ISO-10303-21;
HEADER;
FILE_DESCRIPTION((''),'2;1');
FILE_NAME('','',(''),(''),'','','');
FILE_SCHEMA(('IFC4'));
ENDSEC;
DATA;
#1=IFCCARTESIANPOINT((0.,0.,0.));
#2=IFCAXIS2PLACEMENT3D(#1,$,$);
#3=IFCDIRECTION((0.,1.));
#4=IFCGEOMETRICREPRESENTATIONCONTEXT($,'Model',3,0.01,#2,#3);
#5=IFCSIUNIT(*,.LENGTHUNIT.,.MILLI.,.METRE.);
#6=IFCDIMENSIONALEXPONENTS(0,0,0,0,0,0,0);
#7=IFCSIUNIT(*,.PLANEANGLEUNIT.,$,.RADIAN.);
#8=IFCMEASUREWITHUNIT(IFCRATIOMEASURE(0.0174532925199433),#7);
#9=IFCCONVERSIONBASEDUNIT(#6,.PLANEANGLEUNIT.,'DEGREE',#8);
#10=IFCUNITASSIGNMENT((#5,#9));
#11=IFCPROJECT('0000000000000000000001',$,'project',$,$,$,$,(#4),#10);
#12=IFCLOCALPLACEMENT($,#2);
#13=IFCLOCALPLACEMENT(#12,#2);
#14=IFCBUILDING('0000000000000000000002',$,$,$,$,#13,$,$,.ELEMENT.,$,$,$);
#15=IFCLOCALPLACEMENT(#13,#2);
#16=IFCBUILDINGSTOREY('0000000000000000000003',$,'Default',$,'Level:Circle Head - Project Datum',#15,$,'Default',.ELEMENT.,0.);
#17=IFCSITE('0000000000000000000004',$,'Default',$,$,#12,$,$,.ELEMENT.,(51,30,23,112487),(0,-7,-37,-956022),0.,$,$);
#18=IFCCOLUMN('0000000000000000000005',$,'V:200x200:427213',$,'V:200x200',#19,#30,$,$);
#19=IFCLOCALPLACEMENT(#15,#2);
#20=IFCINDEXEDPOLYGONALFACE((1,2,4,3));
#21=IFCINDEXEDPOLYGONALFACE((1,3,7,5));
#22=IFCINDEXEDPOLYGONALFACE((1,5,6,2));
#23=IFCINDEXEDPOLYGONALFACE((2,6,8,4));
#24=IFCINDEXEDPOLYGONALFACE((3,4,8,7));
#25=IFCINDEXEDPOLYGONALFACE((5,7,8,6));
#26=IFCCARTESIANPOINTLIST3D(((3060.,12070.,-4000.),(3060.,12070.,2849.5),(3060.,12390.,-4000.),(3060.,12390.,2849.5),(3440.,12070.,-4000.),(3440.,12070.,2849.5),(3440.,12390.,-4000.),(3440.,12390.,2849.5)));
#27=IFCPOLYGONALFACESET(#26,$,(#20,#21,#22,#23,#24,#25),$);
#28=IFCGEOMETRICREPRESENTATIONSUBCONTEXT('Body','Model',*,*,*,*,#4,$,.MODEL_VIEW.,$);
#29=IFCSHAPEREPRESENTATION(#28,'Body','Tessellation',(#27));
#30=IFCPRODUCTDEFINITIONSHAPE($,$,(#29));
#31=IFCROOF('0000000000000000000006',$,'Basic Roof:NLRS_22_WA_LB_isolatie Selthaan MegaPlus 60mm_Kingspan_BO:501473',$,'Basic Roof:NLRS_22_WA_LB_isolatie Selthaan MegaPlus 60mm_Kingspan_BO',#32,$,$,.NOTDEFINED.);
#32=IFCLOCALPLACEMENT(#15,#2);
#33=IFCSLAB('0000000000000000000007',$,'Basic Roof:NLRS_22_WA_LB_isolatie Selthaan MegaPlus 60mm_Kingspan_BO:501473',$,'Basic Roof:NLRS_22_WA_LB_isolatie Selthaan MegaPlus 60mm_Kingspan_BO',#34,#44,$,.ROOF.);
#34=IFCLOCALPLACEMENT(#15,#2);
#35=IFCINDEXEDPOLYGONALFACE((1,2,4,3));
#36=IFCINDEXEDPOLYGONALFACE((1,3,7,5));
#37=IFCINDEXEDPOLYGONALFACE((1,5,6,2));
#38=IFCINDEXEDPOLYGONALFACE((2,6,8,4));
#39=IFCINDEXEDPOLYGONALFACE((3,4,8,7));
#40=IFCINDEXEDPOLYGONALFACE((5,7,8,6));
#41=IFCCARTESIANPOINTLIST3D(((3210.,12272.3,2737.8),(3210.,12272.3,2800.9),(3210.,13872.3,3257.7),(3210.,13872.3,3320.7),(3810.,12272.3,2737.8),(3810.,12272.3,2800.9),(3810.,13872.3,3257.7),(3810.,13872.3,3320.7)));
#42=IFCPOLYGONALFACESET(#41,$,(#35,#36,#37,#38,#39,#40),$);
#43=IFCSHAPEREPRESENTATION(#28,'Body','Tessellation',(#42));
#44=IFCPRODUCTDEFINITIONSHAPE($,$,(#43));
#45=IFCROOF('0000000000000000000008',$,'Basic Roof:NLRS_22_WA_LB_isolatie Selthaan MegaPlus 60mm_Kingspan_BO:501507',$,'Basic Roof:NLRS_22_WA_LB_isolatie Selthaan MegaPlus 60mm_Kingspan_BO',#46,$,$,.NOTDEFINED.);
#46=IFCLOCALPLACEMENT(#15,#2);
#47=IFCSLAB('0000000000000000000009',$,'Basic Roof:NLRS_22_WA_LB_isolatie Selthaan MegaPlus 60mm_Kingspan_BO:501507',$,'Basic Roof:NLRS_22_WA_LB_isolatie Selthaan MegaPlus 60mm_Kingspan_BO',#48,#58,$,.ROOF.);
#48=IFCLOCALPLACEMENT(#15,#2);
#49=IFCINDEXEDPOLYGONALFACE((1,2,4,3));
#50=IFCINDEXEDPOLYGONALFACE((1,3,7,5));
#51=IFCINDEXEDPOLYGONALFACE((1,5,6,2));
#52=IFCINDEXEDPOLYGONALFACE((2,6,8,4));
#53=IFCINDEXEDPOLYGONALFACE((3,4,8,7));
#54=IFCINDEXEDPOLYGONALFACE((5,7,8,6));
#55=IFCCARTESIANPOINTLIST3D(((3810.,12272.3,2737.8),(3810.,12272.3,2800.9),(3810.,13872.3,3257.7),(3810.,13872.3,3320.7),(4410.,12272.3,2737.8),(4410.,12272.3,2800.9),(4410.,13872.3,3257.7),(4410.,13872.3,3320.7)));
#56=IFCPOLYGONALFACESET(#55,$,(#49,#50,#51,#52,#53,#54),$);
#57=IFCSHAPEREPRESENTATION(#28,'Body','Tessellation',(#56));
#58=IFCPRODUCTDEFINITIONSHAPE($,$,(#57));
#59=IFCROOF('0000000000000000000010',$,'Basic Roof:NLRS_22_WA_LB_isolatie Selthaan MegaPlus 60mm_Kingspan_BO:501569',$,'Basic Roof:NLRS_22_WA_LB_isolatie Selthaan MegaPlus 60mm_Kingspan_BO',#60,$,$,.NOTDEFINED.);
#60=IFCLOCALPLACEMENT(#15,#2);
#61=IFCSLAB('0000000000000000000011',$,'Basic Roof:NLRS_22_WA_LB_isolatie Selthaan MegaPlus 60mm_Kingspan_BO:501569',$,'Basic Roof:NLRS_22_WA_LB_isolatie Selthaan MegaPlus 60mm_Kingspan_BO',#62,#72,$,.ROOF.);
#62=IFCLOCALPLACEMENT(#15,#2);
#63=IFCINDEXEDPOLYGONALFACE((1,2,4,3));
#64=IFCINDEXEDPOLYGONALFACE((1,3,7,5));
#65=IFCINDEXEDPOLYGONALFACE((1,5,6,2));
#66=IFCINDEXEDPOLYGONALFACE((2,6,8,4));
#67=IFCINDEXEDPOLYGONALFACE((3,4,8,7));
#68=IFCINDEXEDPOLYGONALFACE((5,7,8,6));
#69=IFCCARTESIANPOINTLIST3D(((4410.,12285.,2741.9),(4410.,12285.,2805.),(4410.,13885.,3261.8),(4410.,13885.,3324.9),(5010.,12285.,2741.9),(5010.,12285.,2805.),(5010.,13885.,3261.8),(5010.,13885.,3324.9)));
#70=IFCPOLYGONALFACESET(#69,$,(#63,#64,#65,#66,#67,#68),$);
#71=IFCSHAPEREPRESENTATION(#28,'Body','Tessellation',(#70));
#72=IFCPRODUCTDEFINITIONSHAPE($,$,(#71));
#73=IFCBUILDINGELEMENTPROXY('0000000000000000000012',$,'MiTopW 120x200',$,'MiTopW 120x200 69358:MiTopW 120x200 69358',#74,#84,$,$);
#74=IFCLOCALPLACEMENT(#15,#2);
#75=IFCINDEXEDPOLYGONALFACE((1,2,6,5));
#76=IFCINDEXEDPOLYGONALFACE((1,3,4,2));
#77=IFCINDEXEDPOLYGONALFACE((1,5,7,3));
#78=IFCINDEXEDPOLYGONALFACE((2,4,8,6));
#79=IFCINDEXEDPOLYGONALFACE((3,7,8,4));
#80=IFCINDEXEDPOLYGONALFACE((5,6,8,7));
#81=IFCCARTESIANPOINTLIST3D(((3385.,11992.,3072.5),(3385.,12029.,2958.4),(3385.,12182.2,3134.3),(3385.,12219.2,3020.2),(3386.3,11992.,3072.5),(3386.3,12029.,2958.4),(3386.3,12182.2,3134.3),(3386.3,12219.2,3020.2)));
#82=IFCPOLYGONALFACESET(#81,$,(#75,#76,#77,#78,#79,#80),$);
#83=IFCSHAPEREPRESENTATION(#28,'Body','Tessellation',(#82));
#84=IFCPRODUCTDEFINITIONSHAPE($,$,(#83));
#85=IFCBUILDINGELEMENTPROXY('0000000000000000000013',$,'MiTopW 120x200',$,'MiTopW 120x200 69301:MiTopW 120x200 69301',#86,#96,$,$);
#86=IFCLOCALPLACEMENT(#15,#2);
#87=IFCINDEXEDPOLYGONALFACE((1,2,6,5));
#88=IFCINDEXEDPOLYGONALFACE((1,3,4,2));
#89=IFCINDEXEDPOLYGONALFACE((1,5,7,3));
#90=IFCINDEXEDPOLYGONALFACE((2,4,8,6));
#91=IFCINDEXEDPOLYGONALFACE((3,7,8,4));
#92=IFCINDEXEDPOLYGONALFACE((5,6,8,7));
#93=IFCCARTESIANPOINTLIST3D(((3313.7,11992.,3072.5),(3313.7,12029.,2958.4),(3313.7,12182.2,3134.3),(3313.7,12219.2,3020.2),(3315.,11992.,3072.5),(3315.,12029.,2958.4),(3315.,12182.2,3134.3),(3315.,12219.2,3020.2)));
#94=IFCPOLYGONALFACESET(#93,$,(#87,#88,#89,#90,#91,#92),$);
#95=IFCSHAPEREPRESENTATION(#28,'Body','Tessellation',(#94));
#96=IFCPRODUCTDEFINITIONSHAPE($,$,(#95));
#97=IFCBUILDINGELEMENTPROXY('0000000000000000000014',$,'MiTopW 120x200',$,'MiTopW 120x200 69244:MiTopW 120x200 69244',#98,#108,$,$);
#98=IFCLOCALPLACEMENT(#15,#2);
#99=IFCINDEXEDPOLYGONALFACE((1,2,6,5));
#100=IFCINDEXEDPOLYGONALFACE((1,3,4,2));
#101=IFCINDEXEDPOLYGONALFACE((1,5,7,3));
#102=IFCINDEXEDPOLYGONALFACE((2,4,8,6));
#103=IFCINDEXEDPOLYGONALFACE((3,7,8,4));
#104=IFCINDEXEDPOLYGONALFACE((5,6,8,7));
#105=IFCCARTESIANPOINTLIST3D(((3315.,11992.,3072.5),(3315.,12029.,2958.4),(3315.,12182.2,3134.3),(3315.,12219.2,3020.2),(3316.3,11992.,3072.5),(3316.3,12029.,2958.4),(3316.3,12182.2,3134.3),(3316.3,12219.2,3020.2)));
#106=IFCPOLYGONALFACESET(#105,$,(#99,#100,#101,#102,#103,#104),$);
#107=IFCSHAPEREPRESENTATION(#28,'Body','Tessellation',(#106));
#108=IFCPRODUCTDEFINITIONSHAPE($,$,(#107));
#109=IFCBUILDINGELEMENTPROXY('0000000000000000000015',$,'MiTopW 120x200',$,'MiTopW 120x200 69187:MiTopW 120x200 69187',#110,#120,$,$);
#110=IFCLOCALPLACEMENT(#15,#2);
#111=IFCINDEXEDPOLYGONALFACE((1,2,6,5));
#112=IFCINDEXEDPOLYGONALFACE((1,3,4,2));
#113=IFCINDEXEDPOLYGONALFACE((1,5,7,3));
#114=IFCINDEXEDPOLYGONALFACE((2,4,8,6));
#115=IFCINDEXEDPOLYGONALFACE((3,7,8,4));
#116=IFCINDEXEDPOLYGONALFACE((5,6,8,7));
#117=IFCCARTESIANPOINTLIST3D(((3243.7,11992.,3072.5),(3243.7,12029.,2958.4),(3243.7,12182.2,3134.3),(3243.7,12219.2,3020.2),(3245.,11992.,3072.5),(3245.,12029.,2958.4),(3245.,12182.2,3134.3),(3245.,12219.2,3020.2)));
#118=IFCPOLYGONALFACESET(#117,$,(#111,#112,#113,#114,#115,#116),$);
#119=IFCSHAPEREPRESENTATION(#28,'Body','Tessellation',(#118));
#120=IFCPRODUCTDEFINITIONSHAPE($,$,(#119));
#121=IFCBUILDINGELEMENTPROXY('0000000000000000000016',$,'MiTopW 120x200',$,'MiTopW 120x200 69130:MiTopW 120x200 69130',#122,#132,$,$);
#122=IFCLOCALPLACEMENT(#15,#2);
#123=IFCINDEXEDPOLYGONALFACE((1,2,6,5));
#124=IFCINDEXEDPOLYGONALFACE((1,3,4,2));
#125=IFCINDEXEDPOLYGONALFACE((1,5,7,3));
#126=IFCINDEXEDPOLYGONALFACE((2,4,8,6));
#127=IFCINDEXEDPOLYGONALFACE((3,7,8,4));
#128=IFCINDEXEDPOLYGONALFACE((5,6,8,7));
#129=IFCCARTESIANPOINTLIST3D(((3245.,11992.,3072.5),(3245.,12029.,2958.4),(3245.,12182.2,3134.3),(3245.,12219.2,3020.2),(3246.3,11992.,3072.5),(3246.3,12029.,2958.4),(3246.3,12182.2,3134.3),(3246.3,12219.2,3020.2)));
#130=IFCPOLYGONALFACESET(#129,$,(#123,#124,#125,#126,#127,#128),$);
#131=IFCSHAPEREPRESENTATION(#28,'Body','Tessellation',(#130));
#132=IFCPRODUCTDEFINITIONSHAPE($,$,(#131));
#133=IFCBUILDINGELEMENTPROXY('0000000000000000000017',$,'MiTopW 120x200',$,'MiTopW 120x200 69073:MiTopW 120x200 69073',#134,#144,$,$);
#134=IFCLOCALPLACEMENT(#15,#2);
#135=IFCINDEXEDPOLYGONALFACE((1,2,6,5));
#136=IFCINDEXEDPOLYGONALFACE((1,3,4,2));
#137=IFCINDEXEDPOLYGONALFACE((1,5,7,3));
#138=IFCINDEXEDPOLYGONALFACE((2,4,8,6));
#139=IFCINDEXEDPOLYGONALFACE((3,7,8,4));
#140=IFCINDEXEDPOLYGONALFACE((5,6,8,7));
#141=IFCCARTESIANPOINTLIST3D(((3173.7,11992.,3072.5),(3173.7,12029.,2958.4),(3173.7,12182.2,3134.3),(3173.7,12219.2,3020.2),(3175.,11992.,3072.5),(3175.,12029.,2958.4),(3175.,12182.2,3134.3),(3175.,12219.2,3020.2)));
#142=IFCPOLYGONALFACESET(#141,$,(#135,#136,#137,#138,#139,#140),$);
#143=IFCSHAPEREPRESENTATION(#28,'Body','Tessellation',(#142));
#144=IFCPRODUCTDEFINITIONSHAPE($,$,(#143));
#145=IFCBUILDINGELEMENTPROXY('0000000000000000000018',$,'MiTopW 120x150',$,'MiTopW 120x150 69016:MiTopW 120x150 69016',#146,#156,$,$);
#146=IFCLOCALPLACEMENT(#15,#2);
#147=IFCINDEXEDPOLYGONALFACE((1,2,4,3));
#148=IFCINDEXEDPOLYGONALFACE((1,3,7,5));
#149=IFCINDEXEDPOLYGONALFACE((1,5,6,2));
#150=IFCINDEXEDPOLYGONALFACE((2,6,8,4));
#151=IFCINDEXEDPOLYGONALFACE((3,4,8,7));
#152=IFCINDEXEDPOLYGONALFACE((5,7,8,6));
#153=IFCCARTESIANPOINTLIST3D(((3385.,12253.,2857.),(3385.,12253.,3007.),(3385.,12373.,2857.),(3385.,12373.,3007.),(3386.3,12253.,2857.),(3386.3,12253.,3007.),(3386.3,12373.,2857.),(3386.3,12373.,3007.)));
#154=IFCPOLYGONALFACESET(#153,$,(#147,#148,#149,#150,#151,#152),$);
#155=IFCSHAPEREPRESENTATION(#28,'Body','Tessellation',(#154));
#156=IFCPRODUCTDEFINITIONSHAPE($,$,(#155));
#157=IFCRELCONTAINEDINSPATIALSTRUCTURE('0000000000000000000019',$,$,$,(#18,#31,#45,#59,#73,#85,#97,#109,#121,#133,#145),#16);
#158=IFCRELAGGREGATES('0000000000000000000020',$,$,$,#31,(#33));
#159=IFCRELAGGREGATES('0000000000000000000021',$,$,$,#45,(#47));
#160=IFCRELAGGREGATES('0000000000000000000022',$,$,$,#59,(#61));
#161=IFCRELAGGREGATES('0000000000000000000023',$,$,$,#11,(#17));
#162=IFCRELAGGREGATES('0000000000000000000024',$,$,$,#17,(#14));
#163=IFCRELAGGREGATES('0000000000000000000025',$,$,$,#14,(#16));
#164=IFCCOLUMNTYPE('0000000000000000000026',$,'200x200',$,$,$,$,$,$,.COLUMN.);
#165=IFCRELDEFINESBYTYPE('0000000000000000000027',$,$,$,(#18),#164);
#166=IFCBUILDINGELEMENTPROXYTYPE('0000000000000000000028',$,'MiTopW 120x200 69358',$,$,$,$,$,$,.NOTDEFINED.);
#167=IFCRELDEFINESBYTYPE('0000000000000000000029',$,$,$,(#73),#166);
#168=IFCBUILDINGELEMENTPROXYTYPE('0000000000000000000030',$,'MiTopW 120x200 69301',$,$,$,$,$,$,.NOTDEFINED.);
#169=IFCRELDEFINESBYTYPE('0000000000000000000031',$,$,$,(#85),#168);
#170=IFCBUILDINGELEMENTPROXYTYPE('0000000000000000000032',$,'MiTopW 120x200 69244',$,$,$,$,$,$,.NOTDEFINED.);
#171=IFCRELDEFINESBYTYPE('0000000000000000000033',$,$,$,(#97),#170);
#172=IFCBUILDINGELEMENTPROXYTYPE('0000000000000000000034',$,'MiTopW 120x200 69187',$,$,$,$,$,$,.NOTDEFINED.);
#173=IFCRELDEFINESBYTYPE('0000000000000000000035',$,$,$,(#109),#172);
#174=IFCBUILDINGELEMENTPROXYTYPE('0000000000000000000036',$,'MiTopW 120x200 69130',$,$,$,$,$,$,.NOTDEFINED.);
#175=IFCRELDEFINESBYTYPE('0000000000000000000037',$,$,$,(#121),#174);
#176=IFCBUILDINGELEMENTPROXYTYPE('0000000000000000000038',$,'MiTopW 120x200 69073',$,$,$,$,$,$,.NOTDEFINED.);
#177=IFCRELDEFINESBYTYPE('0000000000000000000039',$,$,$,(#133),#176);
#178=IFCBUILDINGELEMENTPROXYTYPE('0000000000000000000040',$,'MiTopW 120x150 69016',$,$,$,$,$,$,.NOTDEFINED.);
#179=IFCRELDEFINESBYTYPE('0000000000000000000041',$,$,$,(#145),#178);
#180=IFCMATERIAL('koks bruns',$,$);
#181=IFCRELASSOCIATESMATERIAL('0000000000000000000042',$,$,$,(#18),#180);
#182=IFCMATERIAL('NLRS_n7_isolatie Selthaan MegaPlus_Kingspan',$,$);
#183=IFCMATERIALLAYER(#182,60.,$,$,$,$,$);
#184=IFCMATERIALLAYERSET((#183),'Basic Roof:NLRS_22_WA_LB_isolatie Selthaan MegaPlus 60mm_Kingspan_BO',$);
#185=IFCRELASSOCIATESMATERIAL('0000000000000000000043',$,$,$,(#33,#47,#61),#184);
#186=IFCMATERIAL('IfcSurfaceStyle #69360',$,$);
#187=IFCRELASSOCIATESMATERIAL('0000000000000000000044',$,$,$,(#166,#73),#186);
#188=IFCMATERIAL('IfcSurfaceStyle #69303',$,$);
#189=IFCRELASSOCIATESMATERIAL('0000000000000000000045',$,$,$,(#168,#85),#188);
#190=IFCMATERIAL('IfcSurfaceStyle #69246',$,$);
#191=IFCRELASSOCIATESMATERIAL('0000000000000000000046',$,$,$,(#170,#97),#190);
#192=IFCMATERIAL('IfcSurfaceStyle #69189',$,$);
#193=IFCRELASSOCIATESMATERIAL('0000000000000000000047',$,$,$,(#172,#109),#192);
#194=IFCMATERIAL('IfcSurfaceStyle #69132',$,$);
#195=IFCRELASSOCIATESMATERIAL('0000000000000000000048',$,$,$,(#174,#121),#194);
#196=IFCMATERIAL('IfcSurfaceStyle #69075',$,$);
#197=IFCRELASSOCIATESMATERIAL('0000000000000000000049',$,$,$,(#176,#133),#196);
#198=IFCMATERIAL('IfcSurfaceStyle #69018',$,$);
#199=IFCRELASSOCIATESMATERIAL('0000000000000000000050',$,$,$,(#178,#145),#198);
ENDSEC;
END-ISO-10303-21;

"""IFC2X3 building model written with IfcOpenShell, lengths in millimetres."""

from ifc_helpers import new_model, entity, si_unit, converted_unit, direction, frame, frame_2d, origin, origin_2d_with_axis, place, context, subcontext, project, spatial, polyline, rectangle, outline, extrude, source, transform, mapped, material, layer, layer_set, type_object, type_shapes, element, aggregate, save


model = new_model("IFC2X3")

# Units and contexts
model_context = context("Model", 3, precision=0.01, world=origin(), true_north=direction((0.0, 1.0)))
body_context = subcontext(model_context, "Body", "Model", "MODEL_VIEW")
ifc_project = project(units=[si_unit("LENGTHUNIT", "METRE", prefix="MILLI"), converted_unit("PLANEANGLEUNIT", "DEGREE", entity("IfcRatioMeasure", 0.0174532925199433), si_unit("PLANEANGLEUNIT", "RADIAN"), dimensions=[0, 0, 0, 0, 0, 0, 0])], contexts=[model_context])

# Site, building, storey
site_placement = place(None, origin())
site = spatial("IfcSite", under=ifc_project, at=site_placement, Name="Default", CompositionType="ELEMENT", RefLatitude=(51, 30, 23, 112487), RefLongitude=(0, -7, -37, -956022), RefElevation=0.0)
building_placement = place(site_placement, origin())
building = spatial("IfcBuilding", under=site, at=building_placement, CompositionType="ELEMENT")
storey_placement = place(building_placement, origin())
storey = spatial("IfcBuildingStorey", under=building, at=storey_placement, Name="Default", ObjectType="Level:Circle Head - Project Datum", LongName="Default", CompositionType="ELEMENT", Elevation=0.0)

# Column
ifc_material_1 = material(Name="koks bruns")
column_type_1 = type_object("IfcColumnType", Name="200x200", PredefinedType="COLUMN")
shared_shape_1 = source(origin(), body_context, "Body", "SweptSolid", [
    extrude(rectangle(XDim=380.0, YDim=320.0, at=origin_2d_with_axis()), frame((160.0, 300.0, -4000.0), z_axis=(0.0, 0.0, 1.0), x_axis=(0.0, -1.0, 0.0)), (0.0, 0.0, 1.0), 6849.5),
])
type_shapes(column_type_1, [shared_shape_1])
column_placement = place(storey_placement, frame((3550.0, 12070.0, 0.0), z_axis=(0.0, 0.0, 1.0), x_axis=(0.0, 1.0, 0.0)))
element("IfcColumn", 1, at=column_placement, inside=storey, type_object=column_type_1, material=ifc_material_1, Name="V:200x200:427213", ObjectType="V:200x200", context=body_context, shape_type="MappedRepresentation", body=[
    mapped(shared_shape_1, transform((0.0, 0.0, 0.0), scale=1.0)),
])

# Roofs, slabs
roof_1_placement = place(storey_placement, frame((3210.0, 12272.3, 2737.8)))
roof_1 = element("IfcRoof", 2, at=roof_1_placement, inside=storey, Name="Basic Roof:NLRS_22_WA_LB_isolatie Selthaan MegaPlus 60mm_Kingspan_BO:501473", ObjectType="Basic Roof:NLRS_22_WA_LB_isolatie Selthaan MegaPlus 60mm_Kingspan_BO", ShapeType="NOTDEFINED")
ifc_material_2 = material(Name="NLRS_n7_isolatie Selthaan MegaPlus_Kingspan")
ifc_layer = layer(ifc_material_2, 60.0)
ifc_layer_set = layer_set([ifc_layer], Name="Basic Roof:NLRS_22_WA_LB_isolatie Selthaan MegaPlus 60mm_Kingspan_BO")
slab_1_placement = place(roof_1_placement, origin())
slab_1 = element("IfcSlab", 3, at=slab_1_placement, material=ifc_layer_set, Name="Basic Roof:NLRS_22_WA_LB_isolatie Selthaan MegaPlus 60mm_Kingspan_BO:501473", ObjectType="Basic Roof:NLRS_22_WA_LB_isolatie Selthaan MegaPlus 60mm_Kingspan_BO", PredefinedType="ROOF", context=body_context, shape_type="SweptSolid", body=[
    extrude(rectangle(XDim=600.0, YDim=1682.3, at=frame_2d((0.0, 0.0), x_axis=(-1.0, 0.0))), frame((300.0, 800.0, 259.9), z_axis=(0.0, -0.309017, 0.951057), x_axis=(1.0, 0.0, 0.0)), (0.0, 0.309017, 0.951057), 63.1),
])
aggregate(roof_1, [slab_1])
roof_2_placement = place(storey_placement, frame((3810.0, 12272.3, 2737.8)))
roof_2 = element("IfcRoof", 4, at=roof_2_placement, inside=storey, Name="Basic Roof:NLRS_22_WA_LB_isolatie Selthaan MegaPlus 60mm_Kingspan_BO:501507", ObjectType="Basic Roof:NLRS_22_WA_LB_isolatie Selthaan MegaPlus 60mm_Kingspan_BO", ShapeType="NOTDEFINED")
slab_2_placement = place(roof_2_placement, origin())
slab_2 = element("IfcSlab", 5, at=slab_2_placement, material=ifc_layer_set, Name="Basic Roof:NLRS_22_WA_LB_isolatie Selthaan MegaPlus 60mm_Kingspan_BO:501507", ObjectType="Basic Roof:NLRS_22_WA_LB_isolatie Selthaan MegaPlus 60mm_Kingspan_BO", PredefinedType="ROOF", context=body_context, shape_type="SweptSolid", body=[
    extrude(rectangle(XDim=600.0, YDim=1682.3, at=frame_2d((0.0, 0.0), x_axis=(-1.0, 0.0))), frame((300.0, 800.0, 259.9), z_axis=(0.0, -0.309017, 0.951057), x_axis=(1.0, 0.0, 0.0)), (0.0, 0.309017, 0.951057), 63.1),
])
aggregate(roof_2, [slab_2])
roof_3_placement = place(storey_placement, frame((4410.0, 12285.0, 2741.9)))
roof_3 = element("IfcRoof", 6, at=roof_3_placement, inside=storey, Name="Basic Roof:NLRS_22_WA_LB_isolatie Selthaan MegaPlus 60mm_Kingspan_BO:501569", ObjectType="Basic Roof:NLRS_22_WA_LB_isolatie Selthaan MegaPlus 60mm_Kingspan_BO", ShapeType="NOTDEFINED")
slab_3_placement = place(roof_3_placement, origin())
slab_3 = element("IfcSlab", 7, at=slab_3_placement, material=ifc_layer_set, Name="Basic Roof:NLRS_22_WA_LB_isolatie Selthaan MegaPlus 60mm_Kingspan_BO:501569", ObjectType="Basic Roof:NLRS_22_WA_LB_isolatie Selthaan MegaPlus 60mm_Kingspan_BO", PredefinedType="ROOF", context=body_context, shape_type="SweptSolid", body=[
    extrude(rectangle(XDim=600.0, YDim=1682.3, at=frame_2d((0.0, 0.0), x_axis=(-1.0, 0.0))), frame((300.0, 800.0, 259.9), z_axis=(0.0, -0.309017, 0.951057), x_axis=(1.0, 0.0, 0.0)), (0.0, 0.309017, 0.951057), 63.1),
])
aggregate(roof_3, [slab_3])

# Building element proxies
ifc_material_3 = material(Name="IfcSurfaceStyle #69360")
building_element_proxy_type_1 = type_object("IfcBuildingElementProxyType", Name="MiTopW 120x200 69358", PredefinedType="NOTDEFINED", material=ifc_material_3)
shared_shape_2 = source(origin(), body_context, "Body", "SweptSolid", [
    extrude(outline(polyline([(-100.0, -60.0), (100.0, -60.0), (100.0, 60.0), (-100.0, 60.0), (-100.0, -60.0)])), frame((100.0, 60.0, 0.0), z_axis=(0.0, 0.0, 1.0), x_axis=(-1.0, 0.0, 0.0)), (0.0, 0.0, 1.0), 1.3),
])
type_shapes(building_element_proxy_type_1, [shared_shape_2])
proxy_1_placement = place(building_placement, frame((3386.3, 11992.0, 3072.5), z_axis=(-1.0, 0.0, 0.0), x_axis=(0.0, 0.951057, 0.309017)))
element("IfcBuildingElementProxy", 8, at=proxy_1_placement, inside=storey, type_object=building_element_proxy_type_1, material=ifc_material_3, Name="MiTopW 120x200", ObjectType="MiTopW 120x200 69358:MiTopW 120x200 69358", context=body_context, shape_type="MappedRepresentation", body=[
    mapped(shared_shape_2, transform((0.0, 0.0, 0.0), scale=1.0)),
])
ifc_material_4 = material(Name="IfcSurfaceStyle #69303")
building_element_proxy_type_2 = type_object("IfcBuildingElementProxyType", Name="MiTopW 120x200 69301", PredefinedType="NOTDEFINED", material=ifc_material_4)
shared_shape_3 = source(origin(), body_context, "Body", "SweptSolid", [
    extrude(outline(polyline([(-100.0, -60.0), (100.0, -60.0), (100.0, 60.0), (-100.0, 60.0), (-100.0, -60.0)])), frame((100.0, 60.0, 0.0), z_axis=(0.0, 0.0, 1.0), x_axis=(-1.0, 0.0, 0.0)), (0.0, 0.0, 1.0), 1.3),
])
type_shapes(building_element_proxy_type_2, [shared_shape_3])
proxy_2_placement = place(building_placement, frame((3315.0, 11992.0, 3072.5), z_axis=(-1.0, 0.0, 0.0), x_axis=(0.0, 0.951057, 0.309017)))
element("IfcBuildingElementProxy", 9, at=proxy_2_placement, inside=storey, type_object=building_element_proxy_type_2, material=ifc_material_4, Name="MiTopW 120x200", ObjectType="MiTopW 120x200 69301:MiTopW 120x200 69301", context=body_context, shape_type="MappedRepresentation", body=[
    mapped(shared_shape_3, transform((0.0, 0.0, 0.0), scale=1.0)),
])
ifc_material_5 = material(Name="IfcSurfaceStyle #69246")
building_element_proxy_type_3 = type_object("IfcBuildingElementProxyType", Name="MiTopW 120x200 69244", PredefinedType="NOTDEFINED", material=ifc_material_5)
shared_shape_4 = source(origin(), body_context, "Body", "SweptSolid", [
    extrude(outline(polyline([(-100.0, -60.0), (100.0, -60.0), (100.0, 60.0), (-100.0, 60.0), (-100.0, -60.0)])), frame((100.0, 60.0, 0.0), z_axis=(0.0, 0.0, 1.0), x_axis=(-1.0, 0.0, 0.0)), (0.0, 0.0, 1.0), 1.3),
])
type_shapes(building_element_proxy_type_3, [shared_shape_4])
proxy_3_placement = place(building_placement, frame((3316.3, 11992.0, 3072.5), z_axis=(-1.0, 0.0, 0.0), x_axis=(0.0, 0.951057, 0.309017)))
element("IfcBuildingElementProxy", 10, at=proxy_3_placement, inside=storey, type_object=building_element_proxy_type_3, material=ifc_material_5, Name="MiTopW 120x200", ObjectType="MiTopW 120x200 69244:MiTopW 120x200 69244", context=body_context, shape_type="MappedRepresentation", body=[
    mapped(shared_shape_4, transform((0.0, 0.0, 0.0), scale=1.0)),
])
ifc_material_6 = material(Name="IfcSurfaceStyle #69189")
building_element_proxy_type_4 = type_object("IfcBuildingElementProxyType", Name="MiTopW 120x200 69187", PredefinedType="NOTDEFINED", material=ifc_material_6)
shared_shape_5 = source(origin(), body_context, "Body", "SweptSolid", [
    extrude(outline(polyline([(-100.0, -60.0), (100.0, -60.0), (100.0, 60.0), (-100.0, 60.0), (-100.0, -60.0)])), frame((100.0, 60.0, 0.0), z_axis=(0.0, 0.0, 1.0), x_axis=(-1.0, 0.0, 0.0)), (0.0, 0.0, 1.0), 1.3),
])
type_shapes(building_element_proxy_type_4, [shared_shape_5])
proxy_4_placement = place(building_placement, frame((3245.0, 11992.0, 3072.5), z_axis=(-1.0, 0.0, 0.0), x_axis=(0.0, 0.951057, 0.309017)))
element("IfcBuildingElementProxy", 11, at=proxy_4_placement, inside=storey, type_object=building_element_proxy_type_4, material=ifc_material_6, Name="MiTopW 120x200", ObjectType="MiTopW 120x200 69187:MiTopW 120x200 69187", context=body_context, shape_type="MappedRepresentation", body=[
    mapped(shared_shape_5, transform((0.0, 0.0, 0.0), scale=1.0)),
])
ifc_material_7 = material(Name="IfcSurfaceStyle #69132")
building_element_proxy_type_5 = type_object("IfcBuildingElementProxyType", Name="MiTopW 120x200 69130", PredefinedType="NOTDEFINED", material=ifc_material_7)
shared_shape_6 = source(origin(), body_context, "Body", "SweptSolid", [
    extrude(outline(polyline([(-100.0, -60.0), (100.0, -60.0), (100.0, 60.0), (-100.0, 60.0), (-100.0, -60.0)])), frame((100.0, 60.0, 0.0), z_axis=(0.0, 0.0, 1.0), x_axis=(-1.0, 0.0, 0.0)), (0.0, 0.0, 1.0), 1.3),
])
type_shapes(building_element_proxy_type_5, [shared_shape_6])
proxy_5_placement = place(building_placement, frame((3246.3, 11992.0, 3072.5), z_axis=(-1.0, 0.0, 0.0), x_axis=(0.0, 0.951057, 0.309017)))
element("IfcBuildingElementProxy", 12, at=proxy_5_placement, inside=storey, type_object=building_element_proxy_type_5, material=ifc_material_7, Name="MiTopW 120x200", ObjectType="MiTopW 120x200 69130:MiTopW 120x200 69130", context=body_context, shape_type="MappedRepresentation", body=[
    mapped(shared_shape_6, transform((0.0, 0.0, 0.0), scale=1.0)),
])
ifc_material_8 = material(Name="IfcSurfaceStyle #69075")
building_element_proxy_type_6 = type_object("IfcBuildingElementProxyType", Name="MiTopW 120x200 69073", PredefinedType="NOTDEFINED", material=ifc_material_8)
shared_shape_7 = source(origin(), body_context, "Body", "SweptSolid", [
    extrude(outline(polyline([(-100.0, -60.0), (100.0, -60.0), (100.0, 60.0), (-100.0, 60.0), (-100.0, -60.0)])), frame((100.0, 60.0, 0.0), z_axis=(0.0, 0.0, 1.0), x_axis=(-1.0, 0.0, 0.0)), (0.0, 0.0, 1.0), 1.3),
])
type_shapes(building_element_proxy_type_6, [shared_shape_7])
proxy_6_placement = place(building_placement, frame((3175.0, 11992.0, 3072.5), z_axis=(-1.0, 0.0, 0.0), x_axis=(0.0, 0.951057, 0.309017)))
element("IfcBuildingElementProxy", 13, at=proxy_6_placement, inside=storey, type_object=building_element_proxy_type_6, material=ifc_material_8, Name="MiTopW 120x200", ObjectType="MiTopW 120x200 69073:MiTopW 120x200 69073", context=body_context, shape_type="MappedRepresentation", body=[
    mapped(shared_shape_7, transform((0.0, 0.0, 0.0), scale=1.0)),
])
ifc_material_9 = material(Name="IfcSurfaceStyle #69018")
building_element_proxy_type_7 = type_object("IfcBuildingElementProxyType", Name="MiTopW 120x150 69016", PredefinedType="NOTDEFINED", material=ifc_material_9)
shared_shape_8 = source(origin(), body_context, "Body", "SweptSolid", [
    extrude(rectangle(XDim=150.0, YDim=120.0, at=frame_2d((0.0, 0.0), x_axis=(1.0, 0.0))), frame((75.0, 60.0, 0.0), z_axis=(0.0, 0.0, 1.0), x_axis=(-1.0, 0.0, 0.0)), (0.0, 0.0, 1.0), 1.3),
])
type_shapes(building_element_proxy_type_7, [shared_shape_8])
proxy_7_placement = place(building_placement, frame((3386.3, 12373.0, 3007.0), z_axis=(-1.0, 0.0, 0.0), x_axis=(0.0, 0.0, -1.0)))
element("IfcBuildingElementProxy", 14, at=proxy_7_placement, inside=storey, type_object=building_element_proxy_type_7, material=ifc_material_9, Name="MiTopW 120x150", ObjectType="MiTopW 120x150 69016:MiTopW 120x150 69016", context=body_context, shape_type="MappedRepresentation", body=[
    mapped(shared_shape_8, transform((0.0, 0.0, 0.0), scale=1.0)),
])

save(model, "model.ifc")
